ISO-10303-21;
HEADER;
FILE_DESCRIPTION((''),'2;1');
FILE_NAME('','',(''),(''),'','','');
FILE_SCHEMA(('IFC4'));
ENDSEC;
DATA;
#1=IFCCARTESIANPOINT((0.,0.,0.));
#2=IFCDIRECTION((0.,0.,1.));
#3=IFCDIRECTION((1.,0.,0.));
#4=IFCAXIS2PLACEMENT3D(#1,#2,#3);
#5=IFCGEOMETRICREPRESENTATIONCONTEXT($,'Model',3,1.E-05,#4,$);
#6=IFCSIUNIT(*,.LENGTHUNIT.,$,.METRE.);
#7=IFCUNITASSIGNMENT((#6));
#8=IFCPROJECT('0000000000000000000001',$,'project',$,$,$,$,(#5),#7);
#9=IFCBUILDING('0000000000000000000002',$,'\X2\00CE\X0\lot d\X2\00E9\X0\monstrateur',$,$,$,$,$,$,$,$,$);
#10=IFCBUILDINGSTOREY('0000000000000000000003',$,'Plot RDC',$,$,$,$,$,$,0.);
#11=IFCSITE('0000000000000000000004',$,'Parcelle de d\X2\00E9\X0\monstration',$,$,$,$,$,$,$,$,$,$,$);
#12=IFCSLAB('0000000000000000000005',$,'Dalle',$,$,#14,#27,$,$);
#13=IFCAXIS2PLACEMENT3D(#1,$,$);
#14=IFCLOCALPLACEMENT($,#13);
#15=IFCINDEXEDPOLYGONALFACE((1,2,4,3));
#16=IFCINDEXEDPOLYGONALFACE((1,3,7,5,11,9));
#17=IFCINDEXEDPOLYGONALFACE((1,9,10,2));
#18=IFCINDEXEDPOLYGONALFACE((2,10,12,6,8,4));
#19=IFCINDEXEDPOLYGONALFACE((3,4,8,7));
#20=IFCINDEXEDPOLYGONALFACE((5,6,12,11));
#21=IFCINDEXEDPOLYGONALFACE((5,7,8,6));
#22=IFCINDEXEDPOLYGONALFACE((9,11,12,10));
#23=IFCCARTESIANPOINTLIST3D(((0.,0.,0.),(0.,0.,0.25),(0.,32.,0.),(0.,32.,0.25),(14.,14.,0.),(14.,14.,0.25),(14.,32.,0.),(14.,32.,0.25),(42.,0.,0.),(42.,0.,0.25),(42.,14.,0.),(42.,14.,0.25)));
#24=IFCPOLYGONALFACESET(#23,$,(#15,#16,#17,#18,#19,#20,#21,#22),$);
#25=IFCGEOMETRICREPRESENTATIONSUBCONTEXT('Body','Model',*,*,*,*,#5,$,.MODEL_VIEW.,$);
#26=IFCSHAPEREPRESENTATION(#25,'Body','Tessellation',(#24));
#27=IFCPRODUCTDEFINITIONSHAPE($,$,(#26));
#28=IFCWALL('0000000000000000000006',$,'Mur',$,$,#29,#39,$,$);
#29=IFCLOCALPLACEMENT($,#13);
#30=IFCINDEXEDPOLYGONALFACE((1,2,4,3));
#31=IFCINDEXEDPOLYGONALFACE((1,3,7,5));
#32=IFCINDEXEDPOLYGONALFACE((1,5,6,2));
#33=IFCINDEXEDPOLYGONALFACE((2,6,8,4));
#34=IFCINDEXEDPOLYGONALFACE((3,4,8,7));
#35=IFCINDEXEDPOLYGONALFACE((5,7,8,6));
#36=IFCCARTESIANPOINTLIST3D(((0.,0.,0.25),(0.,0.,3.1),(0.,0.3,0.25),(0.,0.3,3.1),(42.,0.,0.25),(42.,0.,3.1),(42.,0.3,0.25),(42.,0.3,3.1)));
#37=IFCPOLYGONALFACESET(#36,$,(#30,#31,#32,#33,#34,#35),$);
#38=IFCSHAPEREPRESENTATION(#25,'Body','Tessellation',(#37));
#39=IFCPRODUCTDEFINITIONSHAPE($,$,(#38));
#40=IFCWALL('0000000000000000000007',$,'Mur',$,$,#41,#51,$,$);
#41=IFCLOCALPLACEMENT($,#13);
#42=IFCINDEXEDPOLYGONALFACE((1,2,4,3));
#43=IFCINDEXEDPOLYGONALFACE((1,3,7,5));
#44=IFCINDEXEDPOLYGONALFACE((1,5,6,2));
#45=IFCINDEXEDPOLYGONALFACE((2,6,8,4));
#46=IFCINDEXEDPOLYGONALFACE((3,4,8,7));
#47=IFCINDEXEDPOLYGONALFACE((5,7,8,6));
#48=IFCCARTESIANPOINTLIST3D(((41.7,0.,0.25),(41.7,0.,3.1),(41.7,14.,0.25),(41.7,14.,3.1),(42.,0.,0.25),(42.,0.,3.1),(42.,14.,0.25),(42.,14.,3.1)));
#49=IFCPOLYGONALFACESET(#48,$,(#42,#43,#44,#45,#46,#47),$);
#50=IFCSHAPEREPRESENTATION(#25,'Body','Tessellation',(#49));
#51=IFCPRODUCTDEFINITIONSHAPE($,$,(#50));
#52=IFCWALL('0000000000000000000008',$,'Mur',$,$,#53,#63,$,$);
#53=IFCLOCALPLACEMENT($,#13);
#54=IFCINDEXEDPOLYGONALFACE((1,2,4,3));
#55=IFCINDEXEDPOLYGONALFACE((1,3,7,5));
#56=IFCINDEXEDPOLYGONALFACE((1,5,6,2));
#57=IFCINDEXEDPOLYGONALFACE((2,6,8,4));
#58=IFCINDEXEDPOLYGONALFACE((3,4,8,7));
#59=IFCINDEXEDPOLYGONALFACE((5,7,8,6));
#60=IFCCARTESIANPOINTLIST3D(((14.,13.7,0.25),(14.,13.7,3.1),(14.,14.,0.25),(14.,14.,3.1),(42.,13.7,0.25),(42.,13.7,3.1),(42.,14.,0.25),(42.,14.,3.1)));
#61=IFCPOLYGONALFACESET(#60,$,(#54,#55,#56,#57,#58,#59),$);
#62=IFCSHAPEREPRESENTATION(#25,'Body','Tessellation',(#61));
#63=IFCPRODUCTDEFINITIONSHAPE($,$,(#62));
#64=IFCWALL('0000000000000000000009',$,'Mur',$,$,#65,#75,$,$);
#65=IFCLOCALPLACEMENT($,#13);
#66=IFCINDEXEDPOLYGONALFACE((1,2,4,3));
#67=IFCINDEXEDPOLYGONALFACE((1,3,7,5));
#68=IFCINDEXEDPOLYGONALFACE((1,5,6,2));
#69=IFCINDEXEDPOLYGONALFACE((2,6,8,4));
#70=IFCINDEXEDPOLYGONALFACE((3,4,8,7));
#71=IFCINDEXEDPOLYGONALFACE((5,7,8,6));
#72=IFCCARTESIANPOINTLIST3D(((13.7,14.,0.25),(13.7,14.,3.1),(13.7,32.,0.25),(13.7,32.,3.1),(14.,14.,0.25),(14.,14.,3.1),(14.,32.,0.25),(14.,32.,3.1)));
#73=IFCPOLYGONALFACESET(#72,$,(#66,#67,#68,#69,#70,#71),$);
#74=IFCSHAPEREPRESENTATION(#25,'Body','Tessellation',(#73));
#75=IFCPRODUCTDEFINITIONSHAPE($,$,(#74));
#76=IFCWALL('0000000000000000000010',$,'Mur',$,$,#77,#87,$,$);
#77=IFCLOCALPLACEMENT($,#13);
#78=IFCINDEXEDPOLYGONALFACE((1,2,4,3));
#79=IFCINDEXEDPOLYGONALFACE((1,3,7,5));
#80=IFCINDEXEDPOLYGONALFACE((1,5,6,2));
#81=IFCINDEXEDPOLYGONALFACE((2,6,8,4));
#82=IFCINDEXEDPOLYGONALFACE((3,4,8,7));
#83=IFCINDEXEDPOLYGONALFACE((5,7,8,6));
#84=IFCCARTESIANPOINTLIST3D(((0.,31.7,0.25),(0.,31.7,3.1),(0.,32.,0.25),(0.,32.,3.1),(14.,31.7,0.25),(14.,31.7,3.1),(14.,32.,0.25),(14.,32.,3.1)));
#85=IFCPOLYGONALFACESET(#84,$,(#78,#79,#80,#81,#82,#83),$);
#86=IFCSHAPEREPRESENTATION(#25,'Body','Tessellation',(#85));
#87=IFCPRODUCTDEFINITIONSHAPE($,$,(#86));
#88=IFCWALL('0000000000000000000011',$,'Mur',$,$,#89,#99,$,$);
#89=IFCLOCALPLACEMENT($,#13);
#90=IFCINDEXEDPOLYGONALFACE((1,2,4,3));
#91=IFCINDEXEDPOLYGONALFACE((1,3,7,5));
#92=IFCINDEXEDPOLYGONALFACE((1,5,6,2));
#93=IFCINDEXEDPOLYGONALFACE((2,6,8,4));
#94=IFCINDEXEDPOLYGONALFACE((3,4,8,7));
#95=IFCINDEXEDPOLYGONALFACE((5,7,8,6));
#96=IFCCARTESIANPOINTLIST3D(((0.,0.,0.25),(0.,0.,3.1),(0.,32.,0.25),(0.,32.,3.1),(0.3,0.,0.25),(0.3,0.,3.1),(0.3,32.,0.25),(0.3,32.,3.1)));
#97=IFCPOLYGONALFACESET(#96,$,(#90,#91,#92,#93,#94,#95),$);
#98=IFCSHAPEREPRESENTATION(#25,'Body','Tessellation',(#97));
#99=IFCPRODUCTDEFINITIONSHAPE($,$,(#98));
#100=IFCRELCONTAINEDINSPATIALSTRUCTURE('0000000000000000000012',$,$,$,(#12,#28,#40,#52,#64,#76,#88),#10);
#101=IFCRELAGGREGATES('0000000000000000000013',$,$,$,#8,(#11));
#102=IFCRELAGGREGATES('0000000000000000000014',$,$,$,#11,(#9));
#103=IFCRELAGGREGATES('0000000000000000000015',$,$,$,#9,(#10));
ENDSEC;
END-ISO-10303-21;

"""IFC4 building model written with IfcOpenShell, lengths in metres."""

from ifc_helpers import new_model, si_unit, frame, origin_with_axes, place, context, subcontext, project, spatial, indexed_curve, outline, extrude, element, save


model = new_model("IFC4")

# Units and contexts
model_context = context("Model", 3, precision=1e-05, world=origin_with_axes())
body_context = subcontext(model_context, "Body", "Model", "MODEL_VIEW")
ifc_project = project(units=[si_unit("LENGTHUNIT", "METRE")], contexts=[model_context])

# Site, building, storey
site = spatial("IfcSite", under=ifc_project, Name="Parcelle de démonstration")
building = spatial("IfcBuilding", under=site, Name="Îlot démonstrateur")
storey = spatial("IfcBuildingStorey", under=building, Name="Plot RDC", Elevation=0.0)

# Slab
slab_placement = place(None, origin_with_axes())
element("IfcSlab", 1, at=slab_placement, inside=storey, Name="Dalle", context=body_context, shape_type="SweptSolid", body=[
    extrude(outline(indexed_curve([(0.0, 0.0), (42.0, 0.0), (42.0, 14.0), (14.0, 14.0), (14.0, 32.0), (0.0, 32.0)])), None, (0.0, 0.0, 1.0), 0.25),
])

# Walls
wall_1_placement = place(None, frame((0.0, 0.0, 0.25), z_axis=(0.0, 0.0, 1.0), x_axis=(1.0, 0.0, 0.0)))
element("IfcWall", 2, at=wall_1_placement, inside=storey, Name="Mur", context=body_context, shape_type="SweptSolid", body=[
    extrude(outline(indexed_curve([(0.0, 0.0), (0.0, 0.3), (42.0, 0.3), (42.0, 0.0), (0.0, 0.0)], self_intersect=False)), origin_with_axes(), (0.0, 0.0, 1.0), 2.85),
])
wall_2_placement = place(None, frame((42.0, 0.0, 0.25), z_axis=(0.0, 0.0, 1.0), x_axis=(0.0, 1.0, 0.0)))
element("IfcWall", 3, at=wall_2_placement, inside=storey, Name="Mur", context=body_context, shape_type="SweptSolid", body=[
    extrude(outline(indexed_curve([(0.0, 0.0), (0.0, 0.3), (14.0, 0.3), (14.0, 0.0), (0.0, 0.0)], self_intersect=False)), origin_with_axes(), (0.0, 0.0, 1.0), 2.85),
])
wall_3_placement = place(None, frame((42.0, 14.0, 0.25), z_axis=(0.0, 0.0, 1.0), x_axis=(-1.0, 0.0, 0.0)))
element("IfcWall", 4, at=wall_3_placement, inside=storey, Name="Mur", context=body_context, shape_type="SweptSolid", body=[
    extrude(outline(indexed_curve([(0.0, 0.0), (0.0, 0.3), (28.0, 0.3), (28.0, 0.0), (0.0, 0.0)], self_intersect=False)), origin_with_axes(), (0.0, 0.0, 1.0), 2.85),
])
wall_4_placement = place(None, frame((14.0, 14.0, 0.25), z_axis=(0.0, 0.0, 1.0), x_axis=(0.0, 1.0, 0.0)))
element("IfcWall", 5, at=wall_4_placement, inside=storey, Name="Mur", context=body_context, shape_type="SweptSolid", body=[
    extrude(outline(indexed_curve([(0.0, 0.0), (0.0, 0.3), (18.0, 0.3), (18.0, 0.0), (0.0, 0.0)], self_intersect=False)), origin_with_axes(), (0.0, 0.0, 1.0), 2.85),
])
wall_5_placement = place(None, frame((14.0, 32.0, 0.25), z_axis=(0.0, 0.0, 1.0), x_axis=(-1.0, 0.0, 0.0)))
element("IfcWall", 6, at=wall_5_placement, inside=storey, Name="Mur", context=body_context, shape_type="SweptSolid", body=[
    extrude(outline(indexed_curve([(0.0, 0.0), (0.0, 0.3), (14.0, 0.3), (14.0, 0.0), (0.0, 0.0)], self_intersect=False)), origin_with_axes(), (0.0, 0.0, 1.0), 2.85),
])
wall_6_placement = place(None, frame((0.0, 32.0, 0.25), z_axis=(0.0, 0.0, 1.0), x_axis=(0.0, -1.0, 0.0)))
element("IfcWall", 7, at=wall_6_placement, inside=storey, Name="Mur", context=body_context, shape_type="SweptSolid", body=[
    extrude(outline(indexed_curve([(0.0, 0.0), (0.0, 0.3), (32.0, 0.3), (32.0, 0.0), (0.0, 0.0)], self_intersect=False)), origin_with_axes(), (0.0, 0.0, 1.0), 2.85),
])

save(model, "model.ifc")
